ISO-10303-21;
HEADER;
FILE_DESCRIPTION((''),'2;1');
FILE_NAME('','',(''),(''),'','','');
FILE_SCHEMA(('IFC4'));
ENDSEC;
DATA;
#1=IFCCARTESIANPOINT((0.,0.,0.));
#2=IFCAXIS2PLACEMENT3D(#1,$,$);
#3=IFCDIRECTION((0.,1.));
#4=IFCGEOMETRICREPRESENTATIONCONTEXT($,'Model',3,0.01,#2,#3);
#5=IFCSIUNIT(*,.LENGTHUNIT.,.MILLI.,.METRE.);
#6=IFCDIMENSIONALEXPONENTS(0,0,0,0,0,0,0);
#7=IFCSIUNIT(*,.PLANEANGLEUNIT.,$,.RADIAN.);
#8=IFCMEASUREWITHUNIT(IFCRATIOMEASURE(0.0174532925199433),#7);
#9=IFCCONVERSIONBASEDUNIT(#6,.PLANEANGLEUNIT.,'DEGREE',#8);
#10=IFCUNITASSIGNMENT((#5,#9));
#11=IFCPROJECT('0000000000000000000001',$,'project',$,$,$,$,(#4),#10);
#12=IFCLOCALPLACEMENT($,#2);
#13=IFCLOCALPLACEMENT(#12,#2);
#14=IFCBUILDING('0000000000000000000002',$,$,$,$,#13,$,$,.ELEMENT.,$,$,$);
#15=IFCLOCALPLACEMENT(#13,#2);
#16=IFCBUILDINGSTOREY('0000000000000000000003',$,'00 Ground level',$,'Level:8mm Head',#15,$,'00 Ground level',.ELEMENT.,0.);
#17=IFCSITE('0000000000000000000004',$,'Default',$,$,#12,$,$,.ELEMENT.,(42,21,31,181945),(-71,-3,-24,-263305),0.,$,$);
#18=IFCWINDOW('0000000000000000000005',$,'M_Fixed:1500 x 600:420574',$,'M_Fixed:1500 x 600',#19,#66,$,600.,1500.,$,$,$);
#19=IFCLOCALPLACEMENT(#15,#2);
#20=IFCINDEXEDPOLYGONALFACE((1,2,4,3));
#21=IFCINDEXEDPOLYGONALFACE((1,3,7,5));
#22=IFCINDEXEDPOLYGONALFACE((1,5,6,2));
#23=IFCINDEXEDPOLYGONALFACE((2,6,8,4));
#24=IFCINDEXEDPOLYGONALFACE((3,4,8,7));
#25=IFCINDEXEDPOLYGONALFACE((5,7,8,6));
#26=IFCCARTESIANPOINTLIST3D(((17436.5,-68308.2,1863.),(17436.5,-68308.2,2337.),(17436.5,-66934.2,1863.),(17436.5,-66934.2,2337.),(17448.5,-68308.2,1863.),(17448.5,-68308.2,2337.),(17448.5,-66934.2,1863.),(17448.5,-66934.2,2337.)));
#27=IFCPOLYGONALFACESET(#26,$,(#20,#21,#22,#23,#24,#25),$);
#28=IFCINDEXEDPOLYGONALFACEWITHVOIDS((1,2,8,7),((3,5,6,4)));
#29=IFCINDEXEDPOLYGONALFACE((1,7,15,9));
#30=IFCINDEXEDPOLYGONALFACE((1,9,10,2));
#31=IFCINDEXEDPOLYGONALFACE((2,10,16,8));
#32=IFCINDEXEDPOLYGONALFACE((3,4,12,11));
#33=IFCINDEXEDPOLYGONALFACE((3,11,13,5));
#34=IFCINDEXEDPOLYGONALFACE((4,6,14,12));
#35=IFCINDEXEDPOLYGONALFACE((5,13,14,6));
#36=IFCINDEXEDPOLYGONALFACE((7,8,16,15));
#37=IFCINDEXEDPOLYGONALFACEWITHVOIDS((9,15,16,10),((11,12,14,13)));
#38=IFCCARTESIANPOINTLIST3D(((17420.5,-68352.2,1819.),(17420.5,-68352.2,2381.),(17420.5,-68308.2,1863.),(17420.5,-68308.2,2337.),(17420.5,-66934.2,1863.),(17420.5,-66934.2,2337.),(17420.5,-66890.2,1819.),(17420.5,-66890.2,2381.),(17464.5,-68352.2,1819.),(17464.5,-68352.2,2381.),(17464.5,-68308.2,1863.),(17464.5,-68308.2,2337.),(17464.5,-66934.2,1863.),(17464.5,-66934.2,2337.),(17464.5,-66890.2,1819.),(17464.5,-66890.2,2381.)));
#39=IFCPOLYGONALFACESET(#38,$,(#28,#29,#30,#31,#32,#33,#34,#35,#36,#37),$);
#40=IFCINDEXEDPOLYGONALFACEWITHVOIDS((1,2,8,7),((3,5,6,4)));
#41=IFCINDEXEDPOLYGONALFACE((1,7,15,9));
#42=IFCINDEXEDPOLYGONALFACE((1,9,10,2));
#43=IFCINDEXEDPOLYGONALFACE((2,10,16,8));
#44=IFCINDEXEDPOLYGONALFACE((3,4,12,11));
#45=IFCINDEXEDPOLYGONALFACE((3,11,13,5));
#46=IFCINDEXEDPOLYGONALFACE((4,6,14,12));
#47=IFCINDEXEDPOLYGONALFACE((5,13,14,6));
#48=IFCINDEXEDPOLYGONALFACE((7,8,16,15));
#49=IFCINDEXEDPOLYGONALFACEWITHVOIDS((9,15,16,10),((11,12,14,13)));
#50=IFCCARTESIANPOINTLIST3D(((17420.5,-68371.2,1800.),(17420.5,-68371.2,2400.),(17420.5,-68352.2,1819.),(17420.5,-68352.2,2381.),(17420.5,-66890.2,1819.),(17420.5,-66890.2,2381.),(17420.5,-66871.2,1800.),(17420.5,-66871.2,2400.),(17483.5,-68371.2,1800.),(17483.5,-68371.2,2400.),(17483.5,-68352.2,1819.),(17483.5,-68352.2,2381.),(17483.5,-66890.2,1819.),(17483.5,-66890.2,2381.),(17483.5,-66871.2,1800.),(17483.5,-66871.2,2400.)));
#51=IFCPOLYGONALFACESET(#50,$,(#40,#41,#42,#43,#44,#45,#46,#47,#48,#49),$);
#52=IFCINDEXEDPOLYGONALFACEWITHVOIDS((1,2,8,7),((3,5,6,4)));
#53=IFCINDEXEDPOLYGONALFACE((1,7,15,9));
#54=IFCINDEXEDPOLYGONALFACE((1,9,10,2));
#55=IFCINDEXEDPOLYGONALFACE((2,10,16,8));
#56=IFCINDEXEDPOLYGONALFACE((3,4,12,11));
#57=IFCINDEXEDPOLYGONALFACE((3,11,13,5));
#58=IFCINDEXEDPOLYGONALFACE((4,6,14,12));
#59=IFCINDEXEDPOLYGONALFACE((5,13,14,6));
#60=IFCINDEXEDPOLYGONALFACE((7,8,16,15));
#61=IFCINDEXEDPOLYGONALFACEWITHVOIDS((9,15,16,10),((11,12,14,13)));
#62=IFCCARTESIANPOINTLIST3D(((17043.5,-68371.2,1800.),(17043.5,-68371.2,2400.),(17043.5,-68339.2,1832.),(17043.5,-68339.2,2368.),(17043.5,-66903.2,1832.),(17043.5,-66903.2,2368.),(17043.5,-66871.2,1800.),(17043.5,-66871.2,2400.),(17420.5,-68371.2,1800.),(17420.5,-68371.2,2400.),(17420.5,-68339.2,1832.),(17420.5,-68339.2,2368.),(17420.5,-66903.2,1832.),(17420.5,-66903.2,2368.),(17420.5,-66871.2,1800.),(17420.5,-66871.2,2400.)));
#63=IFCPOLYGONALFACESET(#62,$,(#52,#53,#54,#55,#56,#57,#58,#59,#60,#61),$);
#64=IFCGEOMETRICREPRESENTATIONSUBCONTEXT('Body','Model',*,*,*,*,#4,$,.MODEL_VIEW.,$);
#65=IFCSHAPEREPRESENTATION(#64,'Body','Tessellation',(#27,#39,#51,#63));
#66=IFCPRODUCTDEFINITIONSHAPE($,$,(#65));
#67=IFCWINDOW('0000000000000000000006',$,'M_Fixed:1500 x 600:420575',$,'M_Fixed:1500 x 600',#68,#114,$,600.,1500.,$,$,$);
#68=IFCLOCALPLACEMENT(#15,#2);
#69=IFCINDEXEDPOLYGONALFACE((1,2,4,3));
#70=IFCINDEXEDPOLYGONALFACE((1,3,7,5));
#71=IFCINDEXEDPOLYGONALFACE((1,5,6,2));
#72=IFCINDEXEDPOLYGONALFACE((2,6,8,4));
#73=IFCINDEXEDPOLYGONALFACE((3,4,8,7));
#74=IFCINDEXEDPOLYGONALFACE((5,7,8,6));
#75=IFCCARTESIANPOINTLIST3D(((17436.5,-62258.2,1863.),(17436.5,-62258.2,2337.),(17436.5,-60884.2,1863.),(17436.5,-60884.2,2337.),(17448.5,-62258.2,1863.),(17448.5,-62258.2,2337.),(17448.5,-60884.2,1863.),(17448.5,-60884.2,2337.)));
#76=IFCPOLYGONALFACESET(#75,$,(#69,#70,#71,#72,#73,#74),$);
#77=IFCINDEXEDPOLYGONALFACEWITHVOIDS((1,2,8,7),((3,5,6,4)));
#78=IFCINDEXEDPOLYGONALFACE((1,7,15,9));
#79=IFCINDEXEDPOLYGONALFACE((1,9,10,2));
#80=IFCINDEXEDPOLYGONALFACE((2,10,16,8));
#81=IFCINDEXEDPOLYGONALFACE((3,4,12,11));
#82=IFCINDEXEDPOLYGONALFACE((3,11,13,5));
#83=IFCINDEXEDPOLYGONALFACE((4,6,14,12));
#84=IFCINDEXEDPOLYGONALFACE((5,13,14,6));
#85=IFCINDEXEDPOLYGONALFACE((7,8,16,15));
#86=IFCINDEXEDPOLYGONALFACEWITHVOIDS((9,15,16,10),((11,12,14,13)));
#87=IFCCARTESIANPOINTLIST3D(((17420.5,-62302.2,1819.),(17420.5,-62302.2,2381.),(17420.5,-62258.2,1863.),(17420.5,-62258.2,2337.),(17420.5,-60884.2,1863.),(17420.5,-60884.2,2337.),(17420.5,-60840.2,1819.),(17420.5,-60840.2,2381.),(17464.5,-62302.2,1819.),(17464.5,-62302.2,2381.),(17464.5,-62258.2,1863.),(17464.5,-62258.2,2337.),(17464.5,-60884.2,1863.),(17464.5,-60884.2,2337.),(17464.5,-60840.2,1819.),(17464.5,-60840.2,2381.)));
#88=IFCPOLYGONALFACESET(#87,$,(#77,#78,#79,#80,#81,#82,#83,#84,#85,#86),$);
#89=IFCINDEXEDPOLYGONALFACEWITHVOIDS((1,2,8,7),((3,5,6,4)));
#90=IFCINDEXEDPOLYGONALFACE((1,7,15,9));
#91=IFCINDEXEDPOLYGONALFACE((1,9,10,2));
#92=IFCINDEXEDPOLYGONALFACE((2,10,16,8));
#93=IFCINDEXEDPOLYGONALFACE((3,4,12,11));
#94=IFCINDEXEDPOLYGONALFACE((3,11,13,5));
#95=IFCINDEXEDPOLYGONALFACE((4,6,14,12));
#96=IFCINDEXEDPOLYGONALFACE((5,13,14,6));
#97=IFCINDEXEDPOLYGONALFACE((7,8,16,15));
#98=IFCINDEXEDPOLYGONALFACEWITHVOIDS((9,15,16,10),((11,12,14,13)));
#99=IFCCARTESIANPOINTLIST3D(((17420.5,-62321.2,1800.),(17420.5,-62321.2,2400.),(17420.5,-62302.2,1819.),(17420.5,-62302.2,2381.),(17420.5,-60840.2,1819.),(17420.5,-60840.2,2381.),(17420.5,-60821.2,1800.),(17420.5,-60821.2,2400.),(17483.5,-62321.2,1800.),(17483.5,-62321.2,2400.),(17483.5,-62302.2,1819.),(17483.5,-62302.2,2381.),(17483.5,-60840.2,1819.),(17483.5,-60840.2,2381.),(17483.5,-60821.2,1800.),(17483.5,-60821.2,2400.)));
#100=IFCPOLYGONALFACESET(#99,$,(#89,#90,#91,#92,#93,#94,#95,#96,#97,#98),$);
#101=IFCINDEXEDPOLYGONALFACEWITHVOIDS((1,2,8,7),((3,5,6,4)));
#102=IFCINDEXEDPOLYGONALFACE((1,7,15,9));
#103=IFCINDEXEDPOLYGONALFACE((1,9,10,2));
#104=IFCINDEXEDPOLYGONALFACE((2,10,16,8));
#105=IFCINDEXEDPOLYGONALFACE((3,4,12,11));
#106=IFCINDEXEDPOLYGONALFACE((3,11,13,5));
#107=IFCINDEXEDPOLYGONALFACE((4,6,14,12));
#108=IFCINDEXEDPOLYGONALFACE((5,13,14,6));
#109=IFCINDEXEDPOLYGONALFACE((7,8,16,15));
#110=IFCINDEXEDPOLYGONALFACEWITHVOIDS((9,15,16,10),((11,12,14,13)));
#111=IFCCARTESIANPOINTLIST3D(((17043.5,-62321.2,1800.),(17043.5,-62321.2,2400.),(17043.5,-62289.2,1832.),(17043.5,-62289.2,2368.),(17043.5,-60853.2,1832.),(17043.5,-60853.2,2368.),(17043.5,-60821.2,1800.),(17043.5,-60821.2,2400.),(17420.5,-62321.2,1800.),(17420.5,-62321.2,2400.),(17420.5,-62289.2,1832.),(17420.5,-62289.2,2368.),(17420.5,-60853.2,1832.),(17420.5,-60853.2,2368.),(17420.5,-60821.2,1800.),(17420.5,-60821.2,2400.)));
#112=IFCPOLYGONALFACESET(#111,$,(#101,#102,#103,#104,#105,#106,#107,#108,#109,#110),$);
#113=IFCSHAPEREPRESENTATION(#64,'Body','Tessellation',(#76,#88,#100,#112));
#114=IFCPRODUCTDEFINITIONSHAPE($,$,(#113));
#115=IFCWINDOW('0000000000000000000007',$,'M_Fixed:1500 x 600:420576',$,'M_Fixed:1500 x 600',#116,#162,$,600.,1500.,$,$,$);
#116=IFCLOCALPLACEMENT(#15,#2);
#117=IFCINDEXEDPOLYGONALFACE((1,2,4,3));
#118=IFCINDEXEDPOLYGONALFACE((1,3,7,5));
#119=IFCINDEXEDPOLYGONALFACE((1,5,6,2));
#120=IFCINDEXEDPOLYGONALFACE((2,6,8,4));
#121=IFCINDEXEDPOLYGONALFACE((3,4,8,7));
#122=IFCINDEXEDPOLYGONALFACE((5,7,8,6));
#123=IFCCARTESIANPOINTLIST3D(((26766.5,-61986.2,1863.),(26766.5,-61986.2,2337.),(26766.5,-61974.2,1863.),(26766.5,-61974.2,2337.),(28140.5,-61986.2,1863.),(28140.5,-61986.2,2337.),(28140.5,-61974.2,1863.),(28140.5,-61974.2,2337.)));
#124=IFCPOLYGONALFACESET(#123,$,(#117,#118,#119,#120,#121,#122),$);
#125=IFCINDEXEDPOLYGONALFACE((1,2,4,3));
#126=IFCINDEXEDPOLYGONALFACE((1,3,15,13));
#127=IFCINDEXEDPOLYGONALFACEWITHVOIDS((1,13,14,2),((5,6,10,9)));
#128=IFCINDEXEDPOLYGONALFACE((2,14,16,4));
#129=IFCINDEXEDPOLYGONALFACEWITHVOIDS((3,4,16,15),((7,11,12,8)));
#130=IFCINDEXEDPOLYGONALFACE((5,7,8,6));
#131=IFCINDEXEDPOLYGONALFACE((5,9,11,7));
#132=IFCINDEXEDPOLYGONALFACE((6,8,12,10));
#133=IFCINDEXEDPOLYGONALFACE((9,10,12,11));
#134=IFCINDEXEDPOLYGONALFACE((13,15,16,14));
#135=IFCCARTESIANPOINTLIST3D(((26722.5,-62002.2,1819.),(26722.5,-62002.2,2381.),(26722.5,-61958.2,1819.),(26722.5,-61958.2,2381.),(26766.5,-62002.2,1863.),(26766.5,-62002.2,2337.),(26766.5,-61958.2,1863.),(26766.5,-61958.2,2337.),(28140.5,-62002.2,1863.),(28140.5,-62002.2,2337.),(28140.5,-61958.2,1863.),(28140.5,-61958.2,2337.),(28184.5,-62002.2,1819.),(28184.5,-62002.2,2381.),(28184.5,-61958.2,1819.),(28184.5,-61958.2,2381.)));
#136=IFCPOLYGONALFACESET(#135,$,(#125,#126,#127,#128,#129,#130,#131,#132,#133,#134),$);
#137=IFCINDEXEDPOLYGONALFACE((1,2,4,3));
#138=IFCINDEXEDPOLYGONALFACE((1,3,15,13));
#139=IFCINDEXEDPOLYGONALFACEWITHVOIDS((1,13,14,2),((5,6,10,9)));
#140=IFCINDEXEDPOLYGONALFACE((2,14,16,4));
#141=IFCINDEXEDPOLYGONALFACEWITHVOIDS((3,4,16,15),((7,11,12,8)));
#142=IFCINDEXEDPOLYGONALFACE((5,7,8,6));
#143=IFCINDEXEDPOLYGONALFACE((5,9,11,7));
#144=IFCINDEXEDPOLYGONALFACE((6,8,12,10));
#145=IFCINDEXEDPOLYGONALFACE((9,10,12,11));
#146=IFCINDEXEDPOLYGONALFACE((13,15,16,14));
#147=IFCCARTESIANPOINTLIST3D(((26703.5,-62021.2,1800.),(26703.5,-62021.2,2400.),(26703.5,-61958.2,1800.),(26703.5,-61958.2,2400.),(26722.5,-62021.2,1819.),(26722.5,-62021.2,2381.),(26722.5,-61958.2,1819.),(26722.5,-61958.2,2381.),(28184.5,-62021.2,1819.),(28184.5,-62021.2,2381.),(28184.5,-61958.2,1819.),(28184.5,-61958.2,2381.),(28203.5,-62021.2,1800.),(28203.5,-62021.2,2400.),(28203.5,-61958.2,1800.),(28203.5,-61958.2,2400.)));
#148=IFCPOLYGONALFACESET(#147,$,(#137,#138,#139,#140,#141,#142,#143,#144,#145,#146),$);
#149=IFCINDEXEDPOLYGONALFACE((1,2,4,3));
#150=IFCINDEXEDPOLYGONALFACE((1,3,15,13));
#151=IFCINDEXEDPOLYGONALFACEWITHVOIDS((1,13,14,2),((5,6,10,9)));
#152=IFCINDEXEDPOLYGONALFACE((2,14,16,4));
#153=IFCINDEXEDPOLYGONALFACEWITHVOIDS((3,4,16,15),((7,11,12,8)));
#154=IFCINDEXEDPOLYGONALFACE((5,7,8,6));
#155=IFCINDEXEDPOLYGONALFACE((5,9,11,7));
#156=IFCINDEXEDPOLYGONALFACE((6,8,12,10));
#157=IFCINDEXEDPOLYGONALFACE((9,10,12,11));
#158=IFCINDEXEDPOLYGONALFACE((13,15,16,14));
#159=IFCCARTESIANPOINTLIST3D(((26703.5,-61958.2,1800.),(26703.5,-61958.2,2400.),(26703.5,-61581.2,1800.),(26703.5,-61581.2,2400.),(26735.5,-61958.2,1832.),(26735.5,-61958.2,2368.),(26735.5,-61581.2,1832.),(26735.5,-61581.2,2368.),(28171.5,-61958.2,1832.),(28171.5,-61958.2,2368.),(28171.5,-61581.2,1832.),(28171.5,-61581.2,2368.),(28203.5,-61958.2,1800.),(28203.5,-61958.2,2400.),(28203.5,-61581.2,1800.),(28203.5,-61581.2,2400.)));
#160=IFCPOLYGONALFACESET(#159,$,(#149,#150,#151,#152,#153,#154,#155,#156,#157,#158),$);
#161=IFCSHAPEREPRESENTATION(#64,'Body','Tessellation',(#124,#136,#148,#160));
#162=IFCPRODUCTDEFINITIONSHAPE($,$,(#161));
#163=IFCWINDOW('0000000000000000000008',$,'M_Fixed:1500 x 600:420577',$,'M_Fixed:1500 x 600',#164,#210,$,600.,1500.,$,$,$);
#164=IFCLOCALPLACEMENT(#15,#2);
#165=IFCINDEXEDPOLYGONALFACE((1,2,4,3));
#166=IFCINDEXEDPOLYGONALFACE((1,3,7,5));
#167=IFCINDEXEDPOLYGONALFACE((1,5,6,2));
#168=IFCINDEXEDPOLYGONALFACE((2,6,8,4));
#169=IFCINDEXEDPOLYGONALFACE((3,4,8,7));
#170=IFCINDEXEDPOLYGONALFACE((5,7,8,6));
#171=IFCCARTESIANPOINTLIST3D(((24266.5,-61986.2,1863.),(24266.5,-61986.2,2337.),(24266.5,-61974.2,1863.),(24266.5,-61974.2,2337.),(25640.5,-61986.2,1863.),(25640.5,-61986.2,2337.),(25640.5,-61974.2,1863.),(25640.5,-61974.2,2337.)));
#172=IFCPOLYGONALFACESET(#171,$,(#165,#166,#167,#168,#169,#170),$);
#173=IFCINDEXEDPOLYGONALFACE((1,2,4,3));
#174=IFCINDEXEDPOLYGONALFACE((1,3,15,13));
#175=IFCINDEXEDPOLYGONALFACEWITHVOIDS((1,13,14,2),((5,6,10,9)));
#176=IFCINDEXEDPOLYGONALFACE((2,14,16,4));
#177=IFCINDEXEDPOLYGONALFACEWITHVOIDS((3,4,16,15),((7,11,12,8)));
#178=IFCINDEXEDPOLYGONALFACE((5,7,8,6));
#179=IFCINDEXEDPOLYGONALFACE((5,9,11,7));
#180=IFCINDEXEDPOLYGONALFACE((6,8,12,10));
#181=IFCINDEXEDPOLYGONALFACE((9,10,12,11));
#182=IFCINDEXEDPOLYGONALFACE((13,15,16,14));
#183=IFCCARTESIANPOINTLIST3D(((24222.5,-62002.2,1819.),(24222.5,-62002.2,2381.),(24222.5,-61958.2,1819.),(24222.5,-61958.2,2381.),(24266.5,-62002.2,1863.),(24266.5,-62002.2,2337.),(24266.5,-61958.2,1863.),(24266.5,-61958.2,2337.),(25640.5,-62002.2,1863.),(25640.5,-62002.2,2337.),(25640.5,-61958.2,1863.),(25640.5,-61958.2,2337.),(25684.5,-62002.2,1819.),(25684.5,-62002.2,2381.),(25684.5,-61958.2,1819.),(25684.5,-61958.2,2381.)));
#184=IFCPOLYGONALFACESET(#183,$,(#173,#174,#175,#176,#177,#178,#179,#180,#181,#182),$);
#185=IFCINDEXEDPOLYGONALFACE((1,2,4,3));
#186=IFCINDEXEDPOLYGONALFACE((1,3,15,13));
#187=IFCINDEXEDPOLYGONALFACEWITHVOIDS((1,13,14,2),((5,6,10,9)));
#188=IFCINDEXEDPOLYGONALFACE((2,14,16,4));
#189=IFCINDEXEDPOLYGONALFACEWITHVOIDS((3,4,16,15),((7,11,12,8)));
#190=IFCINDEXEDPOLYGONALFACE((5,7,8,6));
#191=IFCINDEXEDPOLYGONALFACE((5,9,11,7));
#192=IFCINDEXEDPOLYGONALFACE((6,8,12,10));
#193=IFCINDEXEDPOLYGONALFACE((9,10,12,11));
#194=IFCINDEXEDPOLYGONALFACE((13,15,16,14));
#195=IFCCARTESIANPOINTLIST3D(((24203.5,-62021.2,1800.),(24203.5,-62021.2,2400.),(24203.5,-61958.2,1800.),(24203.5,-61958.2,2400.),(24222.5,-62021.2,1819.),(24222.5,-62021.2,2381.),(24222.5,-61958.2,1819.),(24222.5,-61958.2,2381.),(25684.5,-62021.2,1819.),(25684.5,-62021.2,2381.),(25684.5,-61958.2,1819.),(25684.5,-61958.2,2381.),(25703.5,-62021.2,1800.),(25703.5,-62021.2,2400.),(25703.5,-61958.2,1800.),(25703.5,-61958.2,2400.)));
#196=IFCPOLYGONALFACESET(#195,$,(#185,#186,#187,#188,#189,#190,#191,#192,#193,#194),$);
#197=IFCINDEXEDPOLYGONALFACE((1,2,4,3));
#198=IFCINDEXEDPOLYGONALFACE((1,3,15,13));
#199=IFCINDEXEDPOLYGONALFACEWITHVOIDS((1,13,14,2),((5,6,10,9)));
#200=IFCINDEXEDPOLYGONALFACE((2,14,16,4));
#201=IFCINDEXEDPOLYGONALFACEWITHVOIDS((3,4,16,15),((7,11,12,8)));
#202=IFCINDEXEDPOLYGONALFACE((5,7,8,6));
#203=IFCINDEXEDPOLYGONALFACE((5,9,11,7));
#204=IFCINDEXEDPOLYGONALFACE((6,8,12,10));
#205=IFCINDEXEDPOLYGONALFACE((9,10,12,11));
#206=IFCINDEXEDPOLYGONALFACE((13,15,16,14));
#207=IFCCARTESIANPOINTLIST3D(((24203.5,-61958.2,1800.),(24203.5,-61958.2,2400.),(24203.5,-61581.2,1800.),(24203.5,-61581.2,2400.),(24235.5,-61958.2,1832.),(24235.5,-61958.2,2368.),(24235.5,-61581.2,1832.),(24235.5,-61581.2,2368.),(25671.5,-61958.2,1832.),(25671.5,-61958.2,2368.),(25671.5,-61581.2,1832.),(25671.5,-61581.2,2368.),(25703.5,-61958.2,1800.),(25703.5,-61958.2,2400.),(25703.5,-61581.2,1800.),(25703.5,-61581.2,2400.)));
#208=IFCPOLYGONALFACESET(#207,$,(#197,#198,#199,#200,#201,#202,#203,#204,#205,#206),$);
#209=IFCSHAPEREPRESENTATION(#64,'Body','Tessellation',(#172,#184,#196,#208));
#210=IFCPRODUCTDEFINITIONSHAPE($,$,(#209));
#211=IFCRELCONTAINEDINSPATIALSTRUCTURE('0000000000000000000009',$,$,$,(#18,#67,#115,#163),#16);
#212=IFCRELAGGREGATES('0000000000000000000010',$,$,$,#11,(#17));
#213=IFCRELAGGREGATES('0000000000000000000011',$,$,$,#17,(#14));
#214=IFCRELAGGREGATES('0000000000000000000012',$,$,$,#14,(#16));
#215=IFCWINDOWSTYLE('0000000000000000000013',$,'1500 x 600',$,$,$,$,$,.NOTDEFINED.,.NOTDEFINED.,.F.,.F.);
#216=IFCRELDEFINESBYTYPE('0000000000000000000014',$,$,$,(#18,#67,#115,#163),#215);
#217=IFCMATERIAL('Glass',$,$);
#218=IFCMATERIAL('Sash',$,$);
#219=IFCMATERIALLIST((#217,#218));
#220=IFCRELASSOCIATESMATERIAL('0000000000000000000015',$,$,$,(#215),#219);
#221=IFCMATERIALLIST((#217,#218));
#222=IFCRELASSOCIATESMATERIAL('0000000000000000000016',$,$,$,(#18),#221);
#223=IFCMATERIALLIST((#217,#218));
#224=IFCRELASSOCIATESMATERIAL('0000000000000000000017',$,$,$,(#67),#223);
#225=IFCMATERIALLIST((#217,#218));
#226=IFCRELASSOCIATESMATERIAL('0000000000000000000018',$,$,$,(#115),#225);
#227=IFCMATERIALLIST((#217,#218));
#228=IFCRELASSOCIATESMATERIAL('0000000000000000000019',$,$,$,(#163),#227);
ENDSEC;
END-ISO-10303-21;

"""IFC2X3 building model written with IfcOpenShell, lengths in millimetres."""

from ifc_helpers import new_model, entity, si_unit, converted_unit, direction, frame, origin, origin_2d_with_axis, place, context, subcontext, project, spatial, polyline, rectangle, outline, extrude, source, transform, mapped, material, material_list, type_object, type_shapes, element, save


model = new_model("IFC2X3")

# Units and contexts
model_context = context("Model", 3, precision=0.01, world=origin(), true_north=direction((0.0, 1.0)))
body_context = subcontext(model_context, "Body", "Model", "MODEL_VIEW")
ifc_project = project(units=[si_unit("LENGTHUNIT", "METRE", prefix="MILLI"), converted_unit("PLANEANGLEUNIT", "DEGREE", entity("IfcRatioMeasure", 0.0174532925199433), si_unit("PLANEANGLEUNIT", "RADIAN"), dimensions=[0, 0, 0, 0, 0, 0, 0])], contexts=[model_context])

# Site, building, storey
site_placement = place(None, origin())
site = spatial("IfcSite", under=ifc_project, at=site_placement, Name="Default", CompositionType="ELEMENT", RefLatitude=(42, 21, 31, 181945), RefLongitude=(-71, -3, -24, -263305), RefElevation=0.0)
building_placement = place(site_placement, origin())
building = spatial("IfcBuilding", under=site, at=building_placement, CompositionType="ELEMENT")
storey_placement = place(building_placement, origin())
storey = spatial("IfcBuildingStorey", under=building, at=storey_placement, Name="00 Ground level", ObjectType="Level:8mm Head", LongName="00 Ground level", CompositionType="ELEMENT", Elevation=0.0)

# Windows
ifc_material_1 = material(Name="Glass")
ifc_material_2 = material(Name="Sash")
ifc_material_list_1 = material_list([ifc_material_1, ifc_material_2])
ifc_material_list_2 = material_list([ifc_material_1, ifc_material_2])
window_style_1 = type_object("IfcWindowStyle", Name="1500 x 600", ConstructionType="NOTDEFINED", OperationType="NOTDEFINED", ParameterTakesPrecedence=False, Sizeable=False, material=ifc_material_list_2)
shared_shape_1 = source(origin(), body_context, "Body", "SweptSolid", [
    extrude(rectangle(XDim=1374.0, YDim=12.0, at=origin_2d_with_axis()), frame((750.0, 425.0, 63.0), z_axis=(0.0, 0.0, 1.0), x_axis=(-1.0, 0.0, 0.0)), (0.0, 0.0, 1.0), 474.0),
    extrude(outline(polyline([(-731.0, -281.0), (731.0, -281.0), (731.0, 281.0), (-731.0, 281.0), (-731.0, -281.0)]), holes=[polyline([(-687.0, -237.0), (-687.0, 237.0), (687.0, 237.0), (687.0, -237.0), (-687.0, -237.0)])]), frame((750.0, 447.0, 300.0), z_axis=(0.0, -1.0, 0.0), x_axis=(-1.0, 0.0, 0.0)), (0.0, 0.0, 1.0), 44.0),
    extrude(outline(polyline([(-750.0, -300.0), (750.0, -300.0), (750.0, 300.0), (-750.0, 300.0), (-750.0, -300.0)]), holes=[polyline([(-731.0, -281.0), (-731.0, 281.0), (731.0, 281.0), (731.0, -281.0), (-731.0, -281.0)])]), frame((750.0, 466.0, 300.0), z_axis=(0.0, -1.0, 0.0), x_axis=(-1.0, 0.0, 0.0)), (0.0, 0.0, 1.0), 63.0),
    extrude(outline(polyline([(-750.0, -300.0), (750.0, -300.0), (750.0, 300.0), (-750.0, 300.0), (-750.0, -300.0)]), holes=[polyline([(-718.0, -268.0), (-718.0, 268.0), (718.0, 268.0), (718.0, -268.0), (-718.0, -268.0)])]), frame((750.0, 403.0, 300.0), z_axis=(0.0, -1.0, 0.0), x_axis=(-1.0, 0.0, 0.0)), (0.0, 0.0, 1.0), 377.0),
])
type_shapes(window_style_1, [shared_shape_1])
window_1_placement = place(storey_placement, frame((17017.5, -66871.2, 1800.0), z_axis=(0.0, 0.0, 1.0), x_axis=(0.0, -1.0, 0.0)))
element("IfcWindow", 1, at=window_1_placement, inside=storey, type_object=window_style_1, material=ifc_material_list_1, Name="M_Fixed:1500 x 600:420574", ObjectType="M_Fixed:1500 x 600", OverallHeight=600.0, OverallWidth=1500.0, context=body_context, shape_type="MappedRepresentation", body=[
    mapped(shared_shape_1, transform((0.0, 0.0, 0.0), scale=1.0)),
])
ifc_material_list_3 = material_list([ifc_material_1, ifc_material_2])
window_2_placement = place(storey_placement, frame((17017.5, -60821.2, 1800.0), z_axis=(0.0, 0.0, 1.0), x_axis=(0.0, -1.0, 0.0)))
element("IfcWindow", 2, at=window_2_placement, inside=storey, type_object=window_style_1, material=ifc_material_list_3, Name="M_Fixed:1500 x 600:420575", ObjectType="M_Fixed:1500 x 600", OverallHeight=600.0, OverallWidth=1500.0, context=body_context, shape_type="MappedRepresentation", body=[
    mapped(shared_shape_1, transform((0.0, 0.0, 0.0), scale=1.0)),
])
ifc_material_list_4 = material_list([ifc_material_1, ifc_material_2])
window_3_placement = place(storey_placement, frame((28203.5, -61555.2, 1800.0), z_axis=(0.0, 0.0, 1.0), x_axis=(-1.0, 0.0, 0.0)))
element("IfcWindow", 3, at=window_3_placement, inside=storey, type_object=window_style_1, material=ifc_material_list_4, Name="M_Fixed:1500 x 600:420576", ObjectType="M_Fixed:1500 x 600", OverallHeight=600.0, OverallWidth=1500.0, context=body_context, shape_type="MappedRepresentation", body=[
    mapped(shared_shape_1, transform((0.0, 0.0, 0.0), scale=1.0)),
])
ifc_material_list_5 = material_list([ifc_material_1, ifc_material_2])
window_4_placement = place(storey_placement, frame((25703.5, -61555.2, 1800.0), z_axis=(0.0, 0.0, 1.0), x_axis=(-1.0, 0.0, 0.0)))
element("IfcWindow", 4, at=window_4_placement, inside=storey, type_object=window_style_1, material=ifc_material_list_5, Name="M_Fixed:1500 x 600:420577", ObjectType="M_Fixed:1500 x 600", OverallHeight=600.0, OverallWidth=1500.0, context=body_context, shape_type="MappedRepresentation", body=[
    mapped(shared_shape_1, transform((0.0, 0.0, 0.0), scale=1.0)),
])

save(model, "model.ifc")
